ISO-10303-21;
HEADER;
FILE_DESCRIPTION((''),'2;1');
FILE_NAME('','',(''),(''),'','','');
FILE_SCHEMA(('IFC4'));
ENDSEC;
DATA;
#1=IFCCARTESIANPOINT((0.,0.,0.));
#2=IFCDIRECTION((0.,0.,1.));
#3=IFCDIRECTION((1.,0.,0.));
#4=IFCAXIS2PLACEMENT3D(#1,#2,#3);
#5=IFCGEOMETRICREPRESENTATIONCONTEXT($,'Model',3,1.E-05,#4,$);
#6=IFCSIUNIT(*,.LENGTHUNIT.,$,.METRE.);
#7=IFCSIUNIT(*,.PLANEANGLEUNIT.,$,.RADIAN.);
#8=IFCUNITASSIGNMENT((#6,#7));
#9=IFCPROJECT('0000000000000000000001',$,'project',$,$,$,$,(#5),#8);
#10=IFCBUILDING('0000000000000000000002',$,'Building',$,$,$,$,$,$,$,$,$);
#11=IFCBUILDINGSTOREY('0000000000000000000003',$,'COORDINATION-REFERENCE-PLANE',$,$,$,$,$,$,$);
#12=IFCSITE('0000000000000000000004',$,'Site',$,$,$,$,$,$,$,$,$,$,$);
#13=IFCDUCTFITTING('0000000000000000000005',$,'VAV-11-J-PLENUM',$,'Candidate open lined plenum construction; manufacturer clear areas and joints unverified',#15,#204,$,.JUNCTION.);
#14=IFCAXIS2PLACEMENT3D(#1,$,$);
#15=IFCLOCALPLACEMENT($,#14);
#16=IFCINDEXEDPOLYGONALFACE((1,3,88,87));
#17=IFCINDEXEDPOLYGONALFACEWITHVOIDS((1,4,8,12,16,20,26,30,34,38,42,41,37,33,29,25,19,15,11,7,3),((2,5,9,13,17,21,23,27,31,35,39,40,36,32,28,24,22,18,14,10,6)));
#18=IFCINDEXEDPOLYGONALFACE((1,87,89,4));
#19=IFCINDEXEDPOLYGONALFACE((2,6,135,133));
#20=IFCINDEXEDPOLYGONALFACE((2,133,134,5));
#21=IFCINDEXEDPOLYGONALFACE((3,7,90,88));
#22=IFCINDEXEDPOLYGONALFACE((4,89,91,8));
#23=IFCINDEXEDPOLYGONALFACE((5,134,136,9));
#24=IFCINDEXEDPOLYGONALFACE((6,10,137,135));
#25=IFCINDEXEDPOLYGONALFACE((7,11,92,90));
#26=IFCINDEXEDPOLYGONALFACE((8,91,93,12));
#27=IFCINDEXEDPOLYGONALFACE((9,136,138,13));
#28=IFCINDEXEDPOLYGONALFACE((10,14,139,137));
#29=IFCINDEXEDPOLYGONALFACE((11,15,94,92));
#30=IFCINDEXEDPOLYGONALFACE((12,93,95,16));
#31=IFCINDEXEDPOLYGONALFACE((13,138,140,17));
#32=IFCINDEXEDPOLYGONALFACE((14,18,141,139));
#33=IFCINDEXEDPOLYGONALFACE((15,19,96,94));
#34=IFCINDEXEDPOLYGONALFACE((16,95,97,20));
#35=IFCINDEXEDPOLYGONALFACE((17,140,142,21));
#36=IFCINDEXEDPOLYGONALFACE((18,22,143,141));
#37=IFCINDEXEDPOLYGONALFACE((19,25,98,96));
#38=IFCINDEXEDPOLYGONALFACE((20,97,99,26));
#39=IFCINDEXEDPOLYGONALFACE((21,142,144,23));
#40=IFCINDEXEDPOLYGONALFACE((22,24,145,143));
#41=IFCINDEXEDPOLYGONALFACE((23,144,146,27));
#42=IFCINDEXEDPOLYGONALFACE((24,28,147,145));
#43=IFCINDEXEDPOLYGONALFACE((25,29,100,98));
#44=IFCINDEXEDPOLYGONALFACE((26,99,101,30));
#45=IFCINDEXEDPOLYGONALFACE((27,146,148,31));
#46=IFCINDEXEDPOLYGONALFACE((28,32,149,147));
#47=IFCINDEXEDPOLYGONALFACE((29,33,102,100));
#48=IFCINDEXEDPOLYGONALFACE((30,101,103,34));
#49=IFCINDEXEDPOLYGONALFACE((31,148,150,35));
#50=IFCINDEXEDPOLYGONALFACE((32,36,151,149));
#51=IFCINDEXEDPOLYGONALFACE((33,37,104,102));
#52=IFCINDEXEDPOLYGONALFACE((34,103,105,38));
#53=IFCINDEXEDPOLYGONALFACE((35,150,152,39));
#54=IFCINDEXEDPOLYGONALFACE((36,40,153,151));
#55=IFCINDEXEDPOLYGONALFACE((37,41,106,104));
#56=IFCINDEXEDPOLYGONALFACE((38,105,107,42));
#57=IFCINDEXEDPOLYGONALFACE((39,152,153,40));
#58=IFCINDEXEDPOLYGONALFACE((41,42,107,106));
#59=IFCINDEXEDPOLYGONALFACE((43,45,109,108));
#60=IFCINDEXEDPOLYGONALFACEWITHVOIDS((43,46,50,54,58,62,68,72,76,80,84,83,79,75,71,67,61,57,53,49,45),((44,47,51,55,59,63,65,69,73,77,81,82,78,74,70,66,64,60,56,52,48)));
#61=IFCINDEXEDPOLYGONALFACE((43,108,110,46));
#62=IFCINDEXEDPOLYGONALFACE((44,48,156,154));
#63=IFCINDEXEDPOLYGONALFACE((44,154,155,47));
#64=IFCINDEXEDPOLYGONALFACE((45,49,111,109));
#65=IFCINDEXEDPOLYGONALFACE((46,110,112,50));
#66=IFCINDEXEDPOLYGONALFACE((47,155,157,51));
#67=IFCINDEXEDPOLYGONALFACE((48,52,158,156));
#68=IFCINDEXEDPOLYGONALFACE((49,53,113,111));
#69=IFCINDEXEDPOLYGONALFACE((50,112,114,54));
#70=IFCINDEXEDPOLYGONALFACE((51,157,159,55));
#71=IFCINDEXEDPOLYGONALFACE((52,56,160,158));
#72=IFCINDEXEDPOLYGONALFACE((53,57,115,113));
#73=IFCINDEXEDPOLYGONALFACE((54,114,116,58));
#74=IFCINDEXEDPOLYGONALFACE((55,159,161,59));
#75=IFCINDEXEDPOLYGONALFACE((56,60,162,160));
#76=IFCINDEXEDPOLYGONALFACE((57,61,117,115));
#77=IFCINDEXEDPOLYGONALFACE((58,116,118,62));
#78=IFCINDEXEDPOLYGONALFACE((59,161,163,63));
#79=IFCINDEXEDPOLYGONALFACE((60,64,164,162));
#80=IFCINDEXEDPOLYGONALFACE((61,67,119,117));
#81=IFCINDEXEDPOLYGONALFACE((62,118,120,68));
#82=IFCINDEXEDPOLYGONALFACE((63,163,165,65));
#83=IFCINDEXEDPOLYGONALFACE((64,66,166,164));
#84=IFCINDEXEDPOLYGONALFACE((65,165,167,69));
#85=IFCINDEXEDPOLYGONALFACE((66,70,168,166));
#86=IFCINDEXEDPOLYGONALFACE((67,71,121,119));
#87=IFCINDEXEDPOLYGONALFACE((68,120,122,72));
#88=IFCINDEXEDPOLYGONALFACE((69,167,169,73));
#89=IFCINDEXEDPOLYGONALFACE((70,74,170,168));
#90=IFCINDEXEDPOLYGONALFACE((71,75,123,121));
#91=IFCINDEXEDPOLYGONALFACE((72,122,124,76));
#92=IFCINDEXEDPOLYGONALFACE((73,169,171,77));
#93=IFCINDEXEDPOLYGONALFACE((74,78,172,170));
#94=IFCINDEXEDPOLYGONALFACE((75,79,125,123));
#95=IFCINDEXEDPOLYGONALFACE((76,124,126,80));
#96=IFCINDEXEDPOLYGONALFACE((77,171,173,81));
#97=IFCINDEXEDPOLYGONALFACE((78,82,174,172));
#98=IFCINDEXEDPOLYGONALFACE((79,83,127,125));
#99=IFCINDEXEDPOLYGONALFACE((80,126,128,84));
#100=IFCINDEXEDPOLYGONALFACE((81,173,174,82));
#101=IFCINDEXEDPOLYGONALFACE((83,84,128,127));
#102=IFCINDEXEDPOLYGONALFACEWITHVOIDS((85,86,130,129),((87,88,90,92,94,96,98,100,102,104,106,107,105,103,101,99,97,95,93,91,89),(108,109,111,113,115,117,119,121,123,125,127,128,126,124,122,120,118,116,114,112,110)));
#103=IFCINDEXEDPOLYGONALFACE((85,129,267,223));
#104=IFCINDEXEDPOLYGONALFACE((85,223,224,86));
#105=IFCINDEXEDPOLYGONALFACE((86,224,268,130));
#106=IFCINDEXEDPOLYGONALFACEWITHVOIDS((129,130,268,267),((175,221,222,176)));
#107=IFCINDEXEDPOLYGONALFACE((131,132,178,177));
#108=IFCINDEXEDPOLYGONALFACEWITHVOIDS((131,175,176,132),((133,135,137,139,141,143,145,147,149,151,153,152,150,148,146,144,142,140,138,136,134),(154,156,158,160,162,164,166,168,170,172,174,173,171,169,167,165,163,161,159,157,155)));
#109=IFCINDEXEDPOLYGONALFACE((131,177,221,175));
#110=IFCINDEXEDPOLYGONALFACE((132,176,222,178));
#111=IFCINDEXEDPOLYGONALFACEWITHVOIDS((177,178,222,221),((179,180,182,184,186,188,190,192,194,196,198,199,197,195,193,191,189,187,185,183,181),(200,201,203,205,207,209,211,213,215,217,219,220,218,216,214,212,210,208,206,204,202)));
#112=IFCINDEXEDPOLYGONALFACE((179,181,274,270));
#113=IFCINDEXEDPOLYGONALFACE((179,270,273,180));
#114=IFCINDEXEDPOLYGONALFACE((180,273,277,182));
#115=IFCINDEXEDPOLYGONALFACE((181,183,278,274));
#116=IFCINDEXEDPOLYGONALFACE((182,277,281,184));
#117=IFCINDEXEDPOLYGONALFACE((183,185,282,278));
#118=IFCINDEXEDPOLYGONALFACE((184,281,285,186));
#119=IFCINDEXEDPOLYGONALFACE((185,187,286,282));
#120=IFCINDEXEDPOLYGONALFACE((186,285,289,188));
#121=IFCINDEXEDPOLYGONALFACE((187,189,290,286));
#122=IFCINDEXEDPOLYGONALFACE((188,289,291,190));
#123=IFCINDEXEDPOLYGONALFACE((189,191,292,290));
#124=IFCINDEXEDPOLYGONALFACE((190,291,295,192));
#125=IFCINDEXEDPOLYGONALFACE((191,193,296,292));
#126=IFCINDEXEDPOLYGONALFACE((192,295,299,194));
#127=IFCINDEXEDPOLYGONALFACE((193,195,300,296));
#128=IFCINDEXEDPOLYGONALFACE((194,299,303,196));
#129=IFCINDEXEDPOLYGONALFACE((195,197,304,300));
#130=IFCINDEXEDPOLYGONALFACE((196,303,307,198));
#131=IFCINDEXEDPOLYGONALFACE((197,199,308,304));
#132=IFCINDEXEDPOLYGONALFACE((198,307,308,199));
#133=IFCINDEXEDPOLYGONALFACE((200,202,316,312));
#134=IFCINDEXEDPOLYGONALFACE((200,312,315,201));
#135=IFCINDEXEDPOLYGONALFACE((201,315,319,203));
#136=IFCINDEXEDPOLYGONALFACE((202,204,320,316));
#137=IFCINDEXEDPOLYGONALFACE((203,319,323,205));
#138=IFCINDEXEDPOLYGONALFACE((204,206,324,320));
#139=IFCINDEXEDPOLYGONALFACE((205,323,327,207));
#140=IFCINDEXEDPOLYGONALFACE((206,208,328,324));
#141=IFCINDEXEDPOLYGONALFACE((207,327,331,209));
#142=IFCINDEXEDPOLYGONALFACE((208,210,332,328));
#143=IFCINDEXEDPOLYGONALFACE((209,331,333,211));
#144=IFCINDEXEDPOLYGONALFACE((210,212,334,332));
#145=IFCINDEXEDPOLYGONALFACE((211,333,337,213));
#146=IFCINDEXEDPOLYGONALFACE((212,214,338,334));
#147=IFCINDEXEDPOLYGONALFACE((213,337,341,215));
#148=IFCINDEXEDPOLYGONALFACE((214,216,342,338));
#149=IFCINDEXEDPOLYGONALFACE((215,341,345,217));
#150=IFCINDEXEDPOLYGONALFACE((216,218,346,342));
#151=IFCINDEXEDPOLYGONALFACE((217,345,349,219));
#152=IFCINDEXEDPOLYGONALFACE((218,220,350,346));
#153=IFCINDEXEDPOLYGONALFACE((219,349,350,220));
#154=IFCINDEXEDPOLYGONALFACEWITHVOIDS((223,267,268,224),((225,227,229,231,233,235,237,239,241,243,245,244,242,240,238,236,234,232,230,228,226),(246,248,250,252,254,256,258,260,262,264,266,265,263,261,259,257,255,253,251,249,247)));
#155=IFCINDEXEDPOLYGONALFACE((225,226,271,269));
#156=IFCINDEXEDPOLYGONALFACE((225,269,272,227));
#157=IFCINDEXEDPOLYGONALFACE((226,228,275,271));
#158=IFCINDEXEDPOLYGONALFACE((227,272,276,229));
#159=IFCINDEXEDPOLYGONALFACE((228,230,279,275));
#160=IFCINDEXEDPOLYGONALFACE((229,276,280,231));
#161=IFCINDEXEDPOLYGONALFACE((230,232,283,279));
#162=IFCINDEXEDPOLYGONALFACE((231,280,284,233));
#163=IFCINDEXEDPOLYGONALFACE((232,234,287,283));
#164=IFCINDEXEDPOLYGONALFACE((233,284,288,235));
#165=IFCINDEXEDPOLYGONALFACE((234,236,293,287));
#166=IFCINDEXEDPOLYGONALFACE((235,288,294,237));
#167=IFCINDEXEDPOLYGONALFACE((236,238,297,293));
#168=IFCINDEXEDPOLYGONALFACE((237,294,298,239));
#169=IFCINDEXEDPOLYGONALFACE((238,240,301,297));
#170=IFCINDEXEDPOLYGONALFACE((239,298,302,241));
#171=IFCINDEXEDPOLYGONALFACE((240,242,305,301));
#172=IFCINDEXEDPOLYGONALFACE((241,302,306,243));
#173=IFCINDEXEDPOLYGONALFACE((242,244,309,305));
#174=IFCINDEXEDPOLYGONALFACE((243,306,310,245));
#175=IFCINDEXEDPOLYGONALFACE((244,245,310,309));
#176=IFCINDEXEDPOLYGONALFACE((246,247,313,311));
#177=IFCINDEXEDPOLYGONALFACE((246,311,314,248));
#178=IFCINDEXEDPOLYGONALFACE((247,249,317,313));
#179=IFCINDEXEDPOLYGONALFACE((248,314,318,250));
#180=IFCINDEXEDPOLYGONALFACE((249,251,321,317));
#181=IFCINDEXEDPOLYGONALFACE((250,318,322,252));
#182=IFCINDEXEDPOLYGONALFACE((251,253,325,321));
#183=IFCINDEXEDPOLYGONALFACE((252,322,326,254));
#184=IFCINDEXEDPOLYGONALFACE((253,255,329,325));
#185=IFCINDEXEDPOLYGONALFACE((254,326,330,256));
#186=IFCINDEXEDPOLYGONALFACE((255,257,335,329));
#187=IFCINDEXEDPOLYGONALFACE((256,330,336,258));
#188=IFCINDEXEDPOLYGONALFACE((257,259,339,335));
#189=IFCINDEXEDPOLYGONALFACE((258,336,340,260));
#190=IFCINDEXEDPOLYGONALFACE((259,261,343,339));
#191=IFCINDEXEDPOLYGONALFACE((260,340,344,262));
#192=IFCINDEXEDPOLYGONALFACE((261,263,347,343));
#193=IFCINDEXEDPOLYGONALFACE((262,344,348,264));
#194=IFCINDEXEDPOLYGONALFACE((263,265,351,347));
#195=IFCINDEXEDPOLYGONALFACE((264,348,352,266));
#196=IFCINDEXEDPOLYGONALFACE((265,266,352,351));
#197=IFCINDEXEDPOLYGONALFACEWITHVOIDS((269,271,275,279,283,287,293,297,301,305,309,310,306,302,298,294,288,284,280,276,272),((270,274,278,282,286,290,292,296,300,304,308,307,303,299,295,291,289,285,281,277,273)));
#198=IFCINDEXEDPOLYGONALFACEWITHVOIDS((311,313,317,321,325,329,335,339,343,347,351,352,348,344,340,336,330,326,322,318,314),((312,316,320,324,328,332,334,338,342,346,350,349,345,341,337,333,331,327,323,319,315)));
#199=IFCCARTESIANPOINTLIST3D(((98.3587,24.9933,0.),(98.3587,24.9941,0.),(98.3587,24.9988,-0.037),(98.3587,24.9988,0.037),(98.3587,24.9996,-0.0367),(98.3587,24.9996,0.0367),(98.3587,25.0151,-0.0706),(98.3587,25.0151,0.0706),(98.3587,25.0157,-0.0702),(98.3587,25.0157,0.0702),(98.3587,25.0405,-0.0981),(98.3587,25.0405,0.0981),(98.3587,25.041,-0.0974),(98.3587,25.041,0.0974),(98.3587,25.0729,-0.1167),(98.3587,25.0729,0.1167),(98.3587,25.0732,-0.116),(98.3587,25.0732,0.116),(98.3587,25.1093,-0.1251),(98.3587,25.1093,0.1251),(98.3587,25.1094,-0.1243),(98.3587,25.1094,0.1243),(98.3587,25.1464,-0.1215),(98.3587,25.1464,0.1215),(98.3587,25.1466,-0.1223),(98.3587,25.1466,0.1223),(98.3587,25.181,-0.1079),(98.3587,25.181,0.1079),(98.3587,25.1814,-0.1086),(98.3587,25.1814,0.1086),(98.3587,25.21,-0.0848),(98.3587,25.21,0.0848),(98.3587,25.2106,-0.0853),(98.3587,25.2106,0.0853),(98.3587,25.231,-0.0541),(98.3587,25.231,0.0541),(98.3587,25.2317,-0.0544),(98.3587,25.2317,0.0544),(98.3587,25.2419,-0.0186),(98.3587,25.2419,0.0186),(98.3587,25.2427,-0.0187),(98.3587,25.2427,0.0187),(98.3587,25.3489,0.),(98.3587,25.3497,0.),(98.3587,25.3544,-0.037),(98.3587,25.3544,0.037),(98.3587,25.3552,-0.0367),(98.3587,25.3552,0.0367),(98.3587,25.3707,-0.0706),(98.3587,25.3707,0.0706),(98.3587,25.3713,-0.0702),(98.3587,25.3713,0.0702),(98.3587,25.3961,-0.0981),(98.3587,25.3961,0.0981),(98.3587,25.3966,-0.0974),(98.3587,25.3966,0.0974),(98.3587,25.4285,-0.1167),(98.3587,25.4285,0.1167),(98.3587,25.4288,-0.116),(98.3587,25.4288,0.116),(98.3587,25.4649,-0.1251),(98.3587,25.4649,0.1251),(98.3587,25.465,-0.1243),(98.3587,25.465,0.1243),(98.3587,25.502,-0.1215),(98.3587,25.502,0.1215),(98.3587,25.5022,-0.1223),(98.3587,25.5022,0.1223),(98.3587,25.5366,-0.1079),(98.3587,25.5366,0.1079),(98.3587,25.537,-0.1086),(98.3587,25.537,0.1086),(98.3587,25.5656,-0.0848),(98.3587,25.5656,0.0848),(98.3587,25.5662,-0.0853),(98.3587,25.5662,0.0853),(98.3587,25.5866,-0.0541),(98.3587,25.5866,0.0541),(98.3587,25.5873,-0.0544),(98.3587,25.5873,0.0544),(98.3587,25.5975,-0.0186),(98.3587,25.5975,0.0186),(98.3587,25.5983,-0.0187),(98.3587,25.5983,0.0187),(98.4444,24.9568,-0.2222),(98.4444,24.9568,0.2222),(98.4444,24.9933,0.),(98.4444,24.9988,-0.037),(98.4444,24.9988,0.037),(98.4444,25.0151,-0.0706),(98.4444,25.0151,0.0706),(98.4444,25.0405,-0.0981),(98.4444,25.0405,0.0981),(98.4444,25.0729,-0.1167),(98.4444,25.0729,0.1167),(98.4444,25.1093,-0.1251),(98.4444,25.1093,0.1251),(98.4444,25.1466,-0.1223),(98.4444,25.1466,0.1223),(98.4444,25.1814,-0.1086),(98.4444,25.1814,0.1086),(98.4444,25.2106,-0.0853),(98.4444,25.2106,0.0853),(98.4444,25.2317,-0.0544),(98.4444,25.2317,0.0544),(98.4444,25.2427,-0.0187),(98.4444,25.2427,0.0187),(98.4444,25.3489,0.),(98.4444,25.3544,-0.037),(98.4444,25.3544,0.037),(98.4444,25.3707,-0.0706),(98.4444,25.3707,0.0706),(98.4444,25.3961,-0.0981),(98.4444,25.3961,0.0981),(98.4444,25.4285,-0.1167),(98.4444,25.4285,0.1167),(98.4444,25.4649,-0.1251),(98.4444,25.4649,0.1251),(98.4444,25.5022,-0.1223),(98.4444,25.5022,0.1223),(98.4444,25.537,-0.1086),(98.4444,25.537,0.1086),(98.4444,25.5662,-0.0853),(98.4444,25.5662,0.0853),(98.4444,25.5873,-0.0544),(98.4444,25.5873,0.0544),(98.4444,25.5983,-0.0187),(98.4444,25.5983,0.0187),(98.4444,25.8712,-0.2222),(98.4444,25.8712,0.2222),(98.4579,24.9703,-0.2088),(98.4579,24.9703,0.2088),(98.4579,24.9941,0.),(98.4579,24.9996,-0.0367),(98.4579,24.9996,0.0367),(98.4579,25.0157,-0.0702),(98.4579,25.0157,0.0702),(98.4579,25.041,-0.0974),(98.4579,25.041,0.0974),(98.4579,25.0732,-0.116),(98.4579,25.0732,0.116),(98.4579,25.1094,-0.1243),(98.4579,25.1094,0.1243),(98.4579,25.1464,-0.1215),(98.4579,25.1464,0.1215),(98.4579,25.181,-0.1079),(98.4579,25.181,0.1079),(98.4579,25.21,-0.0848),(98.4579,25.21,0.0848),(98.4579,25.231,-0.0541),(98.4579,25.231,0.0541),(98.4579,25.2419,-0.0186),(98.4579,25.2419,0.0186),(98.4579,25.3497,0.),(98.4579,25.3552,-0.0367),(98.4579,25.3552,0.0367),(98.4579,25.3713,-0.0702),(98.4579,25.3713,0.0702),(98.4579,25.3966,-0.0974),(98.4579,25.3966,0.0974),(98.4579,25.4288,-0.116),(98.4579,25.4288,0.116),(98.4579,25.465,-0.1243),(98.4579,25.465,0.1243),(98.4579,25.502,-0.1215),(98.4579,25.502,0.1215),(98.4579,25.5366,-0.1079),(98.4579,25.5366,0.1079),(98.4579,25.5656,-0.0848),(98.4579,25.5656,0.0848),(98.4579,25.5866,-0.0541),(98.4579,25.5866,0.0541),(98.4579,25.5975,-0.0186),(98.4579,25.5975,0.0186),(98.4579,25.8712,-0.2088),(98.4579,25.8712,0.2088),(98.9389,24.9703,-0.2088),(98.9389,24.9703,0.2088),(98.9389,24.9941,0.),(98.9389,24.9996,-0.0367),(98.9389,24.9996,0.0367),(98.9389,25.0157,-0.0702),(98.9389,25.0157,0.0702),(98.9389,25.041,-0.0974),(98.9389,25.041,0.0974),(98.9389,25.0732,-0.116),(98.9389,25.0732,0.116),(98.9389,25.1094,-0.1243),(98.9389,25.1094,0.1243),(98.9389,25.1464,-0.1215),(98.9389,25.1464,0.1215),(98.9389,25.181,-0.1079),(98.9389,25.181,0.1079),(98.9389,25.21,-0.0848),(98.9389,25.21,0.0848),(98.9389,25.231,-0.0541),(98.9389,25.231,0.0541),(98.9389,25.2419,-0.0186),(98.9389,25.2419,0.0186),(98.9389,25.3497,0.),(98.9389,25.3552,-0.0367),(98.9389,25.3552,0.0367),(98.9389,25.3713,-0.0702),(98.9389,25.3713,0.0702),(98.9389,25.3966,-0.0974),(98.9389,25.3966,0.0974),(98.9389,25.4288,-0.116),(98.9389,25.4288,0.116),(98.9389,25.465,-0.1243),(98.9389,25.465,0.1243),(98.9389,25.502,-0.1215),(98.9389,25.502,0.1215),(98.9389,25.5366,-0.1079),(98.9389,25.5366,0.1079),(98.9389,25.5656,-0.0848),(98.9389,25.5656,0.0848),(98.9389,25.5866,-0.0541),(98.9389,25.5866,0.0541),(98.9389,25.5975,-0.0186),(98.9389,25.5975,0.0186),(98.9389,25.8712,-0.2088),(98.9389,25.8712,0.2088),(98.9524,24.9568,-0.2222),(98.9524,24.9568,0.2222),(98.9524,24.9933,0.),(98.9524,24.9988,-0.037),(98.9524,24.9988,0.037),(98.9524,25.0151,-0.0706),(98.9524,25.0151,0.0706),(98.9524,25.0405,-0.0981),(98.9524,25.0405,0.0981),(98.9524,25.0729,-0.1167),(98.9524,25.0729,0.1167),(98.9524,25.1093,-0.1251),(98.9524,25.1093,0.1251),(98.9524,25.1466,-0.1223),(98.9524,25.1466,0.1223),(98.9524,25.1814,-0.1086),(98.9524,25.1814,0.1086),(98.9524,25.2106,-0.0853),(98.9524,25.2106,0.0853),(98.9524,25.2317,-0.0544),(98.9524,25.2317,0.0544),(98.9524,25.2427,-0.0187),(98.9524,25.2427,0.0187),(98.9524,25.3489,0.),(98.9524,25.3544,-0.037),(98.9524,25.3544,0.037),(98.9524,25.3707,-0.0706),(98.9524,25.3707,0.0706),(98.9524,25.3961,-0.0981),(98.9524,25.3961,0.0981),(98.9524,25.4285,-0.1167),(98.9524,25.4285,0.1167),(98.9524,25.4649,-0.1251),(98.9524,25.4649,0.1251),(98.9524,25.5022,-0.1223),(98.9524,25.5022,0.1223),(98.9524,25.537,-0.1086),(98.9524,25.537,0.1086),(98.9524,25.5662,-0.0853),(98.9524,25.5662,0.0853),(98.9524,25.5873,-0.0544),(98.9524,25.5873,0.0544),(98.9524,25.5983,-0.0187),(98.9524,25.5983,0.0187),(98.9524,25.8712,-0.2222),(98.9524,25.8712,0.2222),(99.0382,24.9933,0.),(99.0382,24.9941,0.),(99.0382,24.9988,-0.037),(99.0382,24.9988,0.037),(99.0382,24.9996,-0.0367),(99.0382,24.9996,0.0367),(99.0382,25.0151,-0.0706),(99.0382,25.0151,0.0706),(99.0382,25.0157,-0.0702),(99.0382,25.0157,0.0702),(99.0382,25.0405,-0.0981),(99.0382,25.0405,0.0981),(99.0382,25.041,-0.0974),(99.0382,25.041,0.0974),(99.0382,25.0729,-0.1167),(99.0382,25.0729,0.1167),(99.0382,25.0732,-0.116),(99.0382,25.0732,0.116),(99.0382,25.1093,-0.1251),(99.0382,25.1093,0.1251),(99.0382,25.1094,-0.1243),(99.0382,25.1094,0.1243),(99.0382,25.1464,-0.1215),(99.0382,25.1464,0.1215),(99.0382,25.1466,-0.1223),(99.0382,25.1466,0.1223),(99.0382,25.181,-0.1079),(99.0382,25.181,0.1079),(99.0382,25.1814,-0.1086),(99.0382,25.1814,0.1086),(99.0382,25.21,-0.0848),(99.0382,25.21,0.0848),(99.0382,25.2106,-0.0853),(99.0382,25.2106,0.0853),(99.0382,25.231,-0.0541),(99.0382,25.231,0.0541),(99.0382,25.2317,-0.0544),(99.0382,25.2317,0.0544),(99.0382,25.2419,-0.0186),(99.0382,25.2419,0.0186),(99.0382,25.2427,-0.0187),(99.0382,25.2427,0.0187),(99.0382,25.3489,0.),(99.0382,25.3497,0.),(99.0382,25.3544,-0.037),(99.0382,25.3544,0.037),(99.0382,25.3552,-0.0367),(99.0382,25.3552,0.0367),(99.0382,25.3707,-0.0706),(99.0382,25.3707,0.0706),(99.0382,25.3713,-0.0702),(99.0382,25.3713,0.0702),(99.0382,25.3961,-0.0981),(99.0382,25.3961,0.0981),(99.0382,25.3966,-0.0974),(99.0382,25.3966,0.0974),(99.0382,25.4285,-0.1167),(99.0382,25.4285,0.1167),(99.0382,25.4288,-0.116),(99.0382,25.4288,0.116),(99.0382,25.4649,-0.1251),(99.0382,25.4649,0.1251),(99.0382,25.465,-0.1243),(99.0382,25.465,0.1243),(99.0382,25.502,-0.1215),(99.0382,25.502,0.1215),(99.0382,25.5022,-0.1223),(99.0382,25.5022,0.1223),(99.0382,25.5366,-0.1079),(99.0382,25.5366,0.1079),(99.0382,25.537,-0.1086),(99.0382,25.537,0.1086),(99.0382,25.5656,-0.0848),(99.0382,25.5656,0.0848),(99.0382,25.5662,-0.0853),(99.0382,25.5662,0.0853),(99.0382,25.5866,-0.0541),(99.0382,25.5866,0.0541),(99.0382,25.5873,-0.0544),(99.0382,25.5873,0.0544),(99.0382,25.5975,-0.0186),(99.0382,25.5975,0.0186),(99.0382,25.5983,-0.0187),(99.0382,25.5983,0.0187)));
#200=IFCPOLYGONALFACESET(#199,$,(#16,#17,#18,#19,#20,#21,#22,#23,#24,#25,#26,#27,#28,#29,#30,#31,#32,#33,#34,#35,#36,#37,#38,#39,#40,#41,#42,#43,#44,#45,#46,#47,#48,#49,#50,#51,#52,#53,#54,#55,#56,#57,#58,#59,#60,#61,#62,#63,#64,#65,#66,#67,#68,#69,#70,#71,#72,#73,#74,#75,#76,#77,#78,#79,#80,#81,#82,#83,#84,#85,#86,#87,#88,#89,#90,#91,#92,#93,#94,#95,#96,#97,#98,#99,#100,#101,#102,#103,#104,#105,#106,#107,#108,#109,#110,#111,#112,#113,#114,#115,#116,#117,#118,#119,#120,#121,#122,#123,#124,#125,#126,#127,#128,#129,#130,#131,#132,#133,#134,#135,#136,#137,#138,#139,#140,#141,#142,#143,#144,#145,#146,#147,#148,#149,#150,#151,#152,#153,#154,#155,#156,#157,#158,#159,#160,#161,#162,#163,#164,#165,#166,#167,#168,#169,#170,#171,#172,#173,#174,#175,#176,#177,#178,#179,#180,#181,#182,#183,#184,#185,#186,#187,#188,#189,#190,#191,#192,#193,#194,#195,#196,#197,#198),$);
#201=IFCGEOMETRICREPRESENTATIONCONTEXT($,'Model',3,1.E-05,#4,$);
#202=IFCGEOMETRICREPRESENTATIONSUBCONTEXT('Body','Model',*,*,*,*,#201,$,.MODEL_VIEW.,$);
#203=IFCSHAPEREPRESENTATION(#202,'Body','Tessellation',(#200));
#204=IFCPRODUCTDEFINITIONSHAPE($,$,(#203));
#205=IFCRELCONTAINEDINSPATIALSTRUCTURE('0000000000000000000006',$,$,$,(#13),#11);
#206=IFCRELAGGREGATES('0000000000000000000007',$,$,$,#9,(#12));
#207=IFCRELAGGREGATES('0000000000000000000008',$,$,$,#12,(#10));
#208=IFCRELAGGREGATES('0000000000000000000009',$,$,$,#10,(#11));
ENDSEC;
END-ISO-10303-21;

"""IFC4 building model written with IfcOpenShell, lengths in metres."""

from ifc_helpers import new_model, si_unit, frame, origin_with_axes, place, context, subcontext, project, spatial, rectangle, circle, extrude, boolean, element, save


model = new_model("IFC4")

# Units and contexts
model_context_1 = context("Model", 3, precision=1e-05, world=origin_with_axes())
model_context_2 = context("Model", 3, precision=1e-05, world=origin_with_axes())
body_context_1 = subcontext(model_context_2, "Body", "Model", "MODEL_VIEW")
ifc_project = project(units=[si_unit("LENGTHUNIT", "METRE"), si_unit("PLANEANGLEUNIT", "RADIAN")], contexts=[model_context_1])

# Site, building, storey
site = spatial("IfcSite", under=ifc_project, Name="Site")
building = spatial("IfcBuilding", under=site, Name="Building")
storey = spatial("IfcBuildingStorey", under=building, Name="COORDINATION-REFERENCE-PLANE")

# Duct fitting
duct_fitting_1_placement = place(None, frame((98.4444, 24.9568, -0.2223), z_axis=(0.0, 0.0, 1.0), x_axis=(1.0, 0.0, 0.0)))
solid_1 = boolean("UNION", boolean("UNION", boolean("UNION", boolean("UNION", extrude(rectangle(XDim=0.481, YDim=0.4175), frame((0.254, 0.9244, 0.2223), z_axis=(0.0, -1.0, 0.0), x_axis=(1.0, 0.0, 0.0)), (0.0, 0.0, 1.0), 0.9109), extrude(circle(Radius=0.1246), frame((0.0235, 0.5175, 0.2223), z_axis=(-1.0, 0.0, 0.0), x_axis=(0.0, -1.0, 0.0)), (0.0, 0.0, 1.0), 0.1192)), extrude(circle(Radius=0.1246), frame((0.4845, 0.5175, 0.2223), z_axis=(1.0, 0.0, 0.0), x_axis=(0.0, -1.0, 0.0)), (0.0, 0.0, 1.0), 0.1192)), extrude(circle(Radius=0.1246), frame((0.0235, 0.1619, 0.2223), z_axis=(-1.0, 0.0, 0.0), x_axis=(0.0, -1.0, 0.0)), (0.0, 0.0, 1.0), 0.1192)), extrude(circle(Radius=0.1246), frame((0.4845, 0.1619, 0.2223), z_axis=(1.0, 0.0, 0.0), x_axis=(0.0, -1.0, 0.0)), (0.0, 0.0, 1.0), 0.1192))
element("IfcDuctFitting", 1, at=duct_fitting_1_placement, inside=storey, Name="VAV-11-J-PLENUM", ObjectType="Candidate open lined plenum construction; manufacturer clear areas and joints unverified", PredefinedType="JUNCTION", context=body_context_1, shape_type="CSG", body=[
    boolean("DIFFERENCE", boolean("UNION", boolean("UNION", boolean("UNION", boolean("UNION", extrude(rectangle(XDim=0.508, YDim=0.4445), frame((0.254, 0.9144, 0.2223), z_axis=(0.0, -1.0, 0.0), x_axis=(1.0, 0.0, 0.0)), (0.0, 0.0, 1.0), 0.9144), extrude(circle(Radius=0.1254), frame((0.0235, 0.5175, 0.2223), z_axis=(-1.0, 0.0, 0.0), x_axis=(0.0, -1.0, 0.0)), (0.0, 0.0, 1.0), 0.1092)), extrude(circle(Radius=0.1254), frame((0.4845, 0.5175, 0.2223), z_axis=(1.0, 0.0, 0.0), x_axis=(0.0, -1.0, 0.0)), (0.0, 0.0, 1.0), 0.1092)), extrude(circle(Radius=0.1254), frame((0.0235, 0.1619, 0.2223), z_axis=(-1.0, 0.0, 0.0), x_axis=(0.0, -1.0, 0.0)), (0.0, 0.0, 1.0), 0.1092)), extrude(circle(Radius=0.1254), frame((0.4845, 0.1619, 0.2223), z_axis=(1.0, 0.0, 0.0), x_axis=(0.0, -1.0, 0.0)), (0.0, 0.0, 1.0), 0.1092)), solid_1),
])

save(model, "model.ifc")
